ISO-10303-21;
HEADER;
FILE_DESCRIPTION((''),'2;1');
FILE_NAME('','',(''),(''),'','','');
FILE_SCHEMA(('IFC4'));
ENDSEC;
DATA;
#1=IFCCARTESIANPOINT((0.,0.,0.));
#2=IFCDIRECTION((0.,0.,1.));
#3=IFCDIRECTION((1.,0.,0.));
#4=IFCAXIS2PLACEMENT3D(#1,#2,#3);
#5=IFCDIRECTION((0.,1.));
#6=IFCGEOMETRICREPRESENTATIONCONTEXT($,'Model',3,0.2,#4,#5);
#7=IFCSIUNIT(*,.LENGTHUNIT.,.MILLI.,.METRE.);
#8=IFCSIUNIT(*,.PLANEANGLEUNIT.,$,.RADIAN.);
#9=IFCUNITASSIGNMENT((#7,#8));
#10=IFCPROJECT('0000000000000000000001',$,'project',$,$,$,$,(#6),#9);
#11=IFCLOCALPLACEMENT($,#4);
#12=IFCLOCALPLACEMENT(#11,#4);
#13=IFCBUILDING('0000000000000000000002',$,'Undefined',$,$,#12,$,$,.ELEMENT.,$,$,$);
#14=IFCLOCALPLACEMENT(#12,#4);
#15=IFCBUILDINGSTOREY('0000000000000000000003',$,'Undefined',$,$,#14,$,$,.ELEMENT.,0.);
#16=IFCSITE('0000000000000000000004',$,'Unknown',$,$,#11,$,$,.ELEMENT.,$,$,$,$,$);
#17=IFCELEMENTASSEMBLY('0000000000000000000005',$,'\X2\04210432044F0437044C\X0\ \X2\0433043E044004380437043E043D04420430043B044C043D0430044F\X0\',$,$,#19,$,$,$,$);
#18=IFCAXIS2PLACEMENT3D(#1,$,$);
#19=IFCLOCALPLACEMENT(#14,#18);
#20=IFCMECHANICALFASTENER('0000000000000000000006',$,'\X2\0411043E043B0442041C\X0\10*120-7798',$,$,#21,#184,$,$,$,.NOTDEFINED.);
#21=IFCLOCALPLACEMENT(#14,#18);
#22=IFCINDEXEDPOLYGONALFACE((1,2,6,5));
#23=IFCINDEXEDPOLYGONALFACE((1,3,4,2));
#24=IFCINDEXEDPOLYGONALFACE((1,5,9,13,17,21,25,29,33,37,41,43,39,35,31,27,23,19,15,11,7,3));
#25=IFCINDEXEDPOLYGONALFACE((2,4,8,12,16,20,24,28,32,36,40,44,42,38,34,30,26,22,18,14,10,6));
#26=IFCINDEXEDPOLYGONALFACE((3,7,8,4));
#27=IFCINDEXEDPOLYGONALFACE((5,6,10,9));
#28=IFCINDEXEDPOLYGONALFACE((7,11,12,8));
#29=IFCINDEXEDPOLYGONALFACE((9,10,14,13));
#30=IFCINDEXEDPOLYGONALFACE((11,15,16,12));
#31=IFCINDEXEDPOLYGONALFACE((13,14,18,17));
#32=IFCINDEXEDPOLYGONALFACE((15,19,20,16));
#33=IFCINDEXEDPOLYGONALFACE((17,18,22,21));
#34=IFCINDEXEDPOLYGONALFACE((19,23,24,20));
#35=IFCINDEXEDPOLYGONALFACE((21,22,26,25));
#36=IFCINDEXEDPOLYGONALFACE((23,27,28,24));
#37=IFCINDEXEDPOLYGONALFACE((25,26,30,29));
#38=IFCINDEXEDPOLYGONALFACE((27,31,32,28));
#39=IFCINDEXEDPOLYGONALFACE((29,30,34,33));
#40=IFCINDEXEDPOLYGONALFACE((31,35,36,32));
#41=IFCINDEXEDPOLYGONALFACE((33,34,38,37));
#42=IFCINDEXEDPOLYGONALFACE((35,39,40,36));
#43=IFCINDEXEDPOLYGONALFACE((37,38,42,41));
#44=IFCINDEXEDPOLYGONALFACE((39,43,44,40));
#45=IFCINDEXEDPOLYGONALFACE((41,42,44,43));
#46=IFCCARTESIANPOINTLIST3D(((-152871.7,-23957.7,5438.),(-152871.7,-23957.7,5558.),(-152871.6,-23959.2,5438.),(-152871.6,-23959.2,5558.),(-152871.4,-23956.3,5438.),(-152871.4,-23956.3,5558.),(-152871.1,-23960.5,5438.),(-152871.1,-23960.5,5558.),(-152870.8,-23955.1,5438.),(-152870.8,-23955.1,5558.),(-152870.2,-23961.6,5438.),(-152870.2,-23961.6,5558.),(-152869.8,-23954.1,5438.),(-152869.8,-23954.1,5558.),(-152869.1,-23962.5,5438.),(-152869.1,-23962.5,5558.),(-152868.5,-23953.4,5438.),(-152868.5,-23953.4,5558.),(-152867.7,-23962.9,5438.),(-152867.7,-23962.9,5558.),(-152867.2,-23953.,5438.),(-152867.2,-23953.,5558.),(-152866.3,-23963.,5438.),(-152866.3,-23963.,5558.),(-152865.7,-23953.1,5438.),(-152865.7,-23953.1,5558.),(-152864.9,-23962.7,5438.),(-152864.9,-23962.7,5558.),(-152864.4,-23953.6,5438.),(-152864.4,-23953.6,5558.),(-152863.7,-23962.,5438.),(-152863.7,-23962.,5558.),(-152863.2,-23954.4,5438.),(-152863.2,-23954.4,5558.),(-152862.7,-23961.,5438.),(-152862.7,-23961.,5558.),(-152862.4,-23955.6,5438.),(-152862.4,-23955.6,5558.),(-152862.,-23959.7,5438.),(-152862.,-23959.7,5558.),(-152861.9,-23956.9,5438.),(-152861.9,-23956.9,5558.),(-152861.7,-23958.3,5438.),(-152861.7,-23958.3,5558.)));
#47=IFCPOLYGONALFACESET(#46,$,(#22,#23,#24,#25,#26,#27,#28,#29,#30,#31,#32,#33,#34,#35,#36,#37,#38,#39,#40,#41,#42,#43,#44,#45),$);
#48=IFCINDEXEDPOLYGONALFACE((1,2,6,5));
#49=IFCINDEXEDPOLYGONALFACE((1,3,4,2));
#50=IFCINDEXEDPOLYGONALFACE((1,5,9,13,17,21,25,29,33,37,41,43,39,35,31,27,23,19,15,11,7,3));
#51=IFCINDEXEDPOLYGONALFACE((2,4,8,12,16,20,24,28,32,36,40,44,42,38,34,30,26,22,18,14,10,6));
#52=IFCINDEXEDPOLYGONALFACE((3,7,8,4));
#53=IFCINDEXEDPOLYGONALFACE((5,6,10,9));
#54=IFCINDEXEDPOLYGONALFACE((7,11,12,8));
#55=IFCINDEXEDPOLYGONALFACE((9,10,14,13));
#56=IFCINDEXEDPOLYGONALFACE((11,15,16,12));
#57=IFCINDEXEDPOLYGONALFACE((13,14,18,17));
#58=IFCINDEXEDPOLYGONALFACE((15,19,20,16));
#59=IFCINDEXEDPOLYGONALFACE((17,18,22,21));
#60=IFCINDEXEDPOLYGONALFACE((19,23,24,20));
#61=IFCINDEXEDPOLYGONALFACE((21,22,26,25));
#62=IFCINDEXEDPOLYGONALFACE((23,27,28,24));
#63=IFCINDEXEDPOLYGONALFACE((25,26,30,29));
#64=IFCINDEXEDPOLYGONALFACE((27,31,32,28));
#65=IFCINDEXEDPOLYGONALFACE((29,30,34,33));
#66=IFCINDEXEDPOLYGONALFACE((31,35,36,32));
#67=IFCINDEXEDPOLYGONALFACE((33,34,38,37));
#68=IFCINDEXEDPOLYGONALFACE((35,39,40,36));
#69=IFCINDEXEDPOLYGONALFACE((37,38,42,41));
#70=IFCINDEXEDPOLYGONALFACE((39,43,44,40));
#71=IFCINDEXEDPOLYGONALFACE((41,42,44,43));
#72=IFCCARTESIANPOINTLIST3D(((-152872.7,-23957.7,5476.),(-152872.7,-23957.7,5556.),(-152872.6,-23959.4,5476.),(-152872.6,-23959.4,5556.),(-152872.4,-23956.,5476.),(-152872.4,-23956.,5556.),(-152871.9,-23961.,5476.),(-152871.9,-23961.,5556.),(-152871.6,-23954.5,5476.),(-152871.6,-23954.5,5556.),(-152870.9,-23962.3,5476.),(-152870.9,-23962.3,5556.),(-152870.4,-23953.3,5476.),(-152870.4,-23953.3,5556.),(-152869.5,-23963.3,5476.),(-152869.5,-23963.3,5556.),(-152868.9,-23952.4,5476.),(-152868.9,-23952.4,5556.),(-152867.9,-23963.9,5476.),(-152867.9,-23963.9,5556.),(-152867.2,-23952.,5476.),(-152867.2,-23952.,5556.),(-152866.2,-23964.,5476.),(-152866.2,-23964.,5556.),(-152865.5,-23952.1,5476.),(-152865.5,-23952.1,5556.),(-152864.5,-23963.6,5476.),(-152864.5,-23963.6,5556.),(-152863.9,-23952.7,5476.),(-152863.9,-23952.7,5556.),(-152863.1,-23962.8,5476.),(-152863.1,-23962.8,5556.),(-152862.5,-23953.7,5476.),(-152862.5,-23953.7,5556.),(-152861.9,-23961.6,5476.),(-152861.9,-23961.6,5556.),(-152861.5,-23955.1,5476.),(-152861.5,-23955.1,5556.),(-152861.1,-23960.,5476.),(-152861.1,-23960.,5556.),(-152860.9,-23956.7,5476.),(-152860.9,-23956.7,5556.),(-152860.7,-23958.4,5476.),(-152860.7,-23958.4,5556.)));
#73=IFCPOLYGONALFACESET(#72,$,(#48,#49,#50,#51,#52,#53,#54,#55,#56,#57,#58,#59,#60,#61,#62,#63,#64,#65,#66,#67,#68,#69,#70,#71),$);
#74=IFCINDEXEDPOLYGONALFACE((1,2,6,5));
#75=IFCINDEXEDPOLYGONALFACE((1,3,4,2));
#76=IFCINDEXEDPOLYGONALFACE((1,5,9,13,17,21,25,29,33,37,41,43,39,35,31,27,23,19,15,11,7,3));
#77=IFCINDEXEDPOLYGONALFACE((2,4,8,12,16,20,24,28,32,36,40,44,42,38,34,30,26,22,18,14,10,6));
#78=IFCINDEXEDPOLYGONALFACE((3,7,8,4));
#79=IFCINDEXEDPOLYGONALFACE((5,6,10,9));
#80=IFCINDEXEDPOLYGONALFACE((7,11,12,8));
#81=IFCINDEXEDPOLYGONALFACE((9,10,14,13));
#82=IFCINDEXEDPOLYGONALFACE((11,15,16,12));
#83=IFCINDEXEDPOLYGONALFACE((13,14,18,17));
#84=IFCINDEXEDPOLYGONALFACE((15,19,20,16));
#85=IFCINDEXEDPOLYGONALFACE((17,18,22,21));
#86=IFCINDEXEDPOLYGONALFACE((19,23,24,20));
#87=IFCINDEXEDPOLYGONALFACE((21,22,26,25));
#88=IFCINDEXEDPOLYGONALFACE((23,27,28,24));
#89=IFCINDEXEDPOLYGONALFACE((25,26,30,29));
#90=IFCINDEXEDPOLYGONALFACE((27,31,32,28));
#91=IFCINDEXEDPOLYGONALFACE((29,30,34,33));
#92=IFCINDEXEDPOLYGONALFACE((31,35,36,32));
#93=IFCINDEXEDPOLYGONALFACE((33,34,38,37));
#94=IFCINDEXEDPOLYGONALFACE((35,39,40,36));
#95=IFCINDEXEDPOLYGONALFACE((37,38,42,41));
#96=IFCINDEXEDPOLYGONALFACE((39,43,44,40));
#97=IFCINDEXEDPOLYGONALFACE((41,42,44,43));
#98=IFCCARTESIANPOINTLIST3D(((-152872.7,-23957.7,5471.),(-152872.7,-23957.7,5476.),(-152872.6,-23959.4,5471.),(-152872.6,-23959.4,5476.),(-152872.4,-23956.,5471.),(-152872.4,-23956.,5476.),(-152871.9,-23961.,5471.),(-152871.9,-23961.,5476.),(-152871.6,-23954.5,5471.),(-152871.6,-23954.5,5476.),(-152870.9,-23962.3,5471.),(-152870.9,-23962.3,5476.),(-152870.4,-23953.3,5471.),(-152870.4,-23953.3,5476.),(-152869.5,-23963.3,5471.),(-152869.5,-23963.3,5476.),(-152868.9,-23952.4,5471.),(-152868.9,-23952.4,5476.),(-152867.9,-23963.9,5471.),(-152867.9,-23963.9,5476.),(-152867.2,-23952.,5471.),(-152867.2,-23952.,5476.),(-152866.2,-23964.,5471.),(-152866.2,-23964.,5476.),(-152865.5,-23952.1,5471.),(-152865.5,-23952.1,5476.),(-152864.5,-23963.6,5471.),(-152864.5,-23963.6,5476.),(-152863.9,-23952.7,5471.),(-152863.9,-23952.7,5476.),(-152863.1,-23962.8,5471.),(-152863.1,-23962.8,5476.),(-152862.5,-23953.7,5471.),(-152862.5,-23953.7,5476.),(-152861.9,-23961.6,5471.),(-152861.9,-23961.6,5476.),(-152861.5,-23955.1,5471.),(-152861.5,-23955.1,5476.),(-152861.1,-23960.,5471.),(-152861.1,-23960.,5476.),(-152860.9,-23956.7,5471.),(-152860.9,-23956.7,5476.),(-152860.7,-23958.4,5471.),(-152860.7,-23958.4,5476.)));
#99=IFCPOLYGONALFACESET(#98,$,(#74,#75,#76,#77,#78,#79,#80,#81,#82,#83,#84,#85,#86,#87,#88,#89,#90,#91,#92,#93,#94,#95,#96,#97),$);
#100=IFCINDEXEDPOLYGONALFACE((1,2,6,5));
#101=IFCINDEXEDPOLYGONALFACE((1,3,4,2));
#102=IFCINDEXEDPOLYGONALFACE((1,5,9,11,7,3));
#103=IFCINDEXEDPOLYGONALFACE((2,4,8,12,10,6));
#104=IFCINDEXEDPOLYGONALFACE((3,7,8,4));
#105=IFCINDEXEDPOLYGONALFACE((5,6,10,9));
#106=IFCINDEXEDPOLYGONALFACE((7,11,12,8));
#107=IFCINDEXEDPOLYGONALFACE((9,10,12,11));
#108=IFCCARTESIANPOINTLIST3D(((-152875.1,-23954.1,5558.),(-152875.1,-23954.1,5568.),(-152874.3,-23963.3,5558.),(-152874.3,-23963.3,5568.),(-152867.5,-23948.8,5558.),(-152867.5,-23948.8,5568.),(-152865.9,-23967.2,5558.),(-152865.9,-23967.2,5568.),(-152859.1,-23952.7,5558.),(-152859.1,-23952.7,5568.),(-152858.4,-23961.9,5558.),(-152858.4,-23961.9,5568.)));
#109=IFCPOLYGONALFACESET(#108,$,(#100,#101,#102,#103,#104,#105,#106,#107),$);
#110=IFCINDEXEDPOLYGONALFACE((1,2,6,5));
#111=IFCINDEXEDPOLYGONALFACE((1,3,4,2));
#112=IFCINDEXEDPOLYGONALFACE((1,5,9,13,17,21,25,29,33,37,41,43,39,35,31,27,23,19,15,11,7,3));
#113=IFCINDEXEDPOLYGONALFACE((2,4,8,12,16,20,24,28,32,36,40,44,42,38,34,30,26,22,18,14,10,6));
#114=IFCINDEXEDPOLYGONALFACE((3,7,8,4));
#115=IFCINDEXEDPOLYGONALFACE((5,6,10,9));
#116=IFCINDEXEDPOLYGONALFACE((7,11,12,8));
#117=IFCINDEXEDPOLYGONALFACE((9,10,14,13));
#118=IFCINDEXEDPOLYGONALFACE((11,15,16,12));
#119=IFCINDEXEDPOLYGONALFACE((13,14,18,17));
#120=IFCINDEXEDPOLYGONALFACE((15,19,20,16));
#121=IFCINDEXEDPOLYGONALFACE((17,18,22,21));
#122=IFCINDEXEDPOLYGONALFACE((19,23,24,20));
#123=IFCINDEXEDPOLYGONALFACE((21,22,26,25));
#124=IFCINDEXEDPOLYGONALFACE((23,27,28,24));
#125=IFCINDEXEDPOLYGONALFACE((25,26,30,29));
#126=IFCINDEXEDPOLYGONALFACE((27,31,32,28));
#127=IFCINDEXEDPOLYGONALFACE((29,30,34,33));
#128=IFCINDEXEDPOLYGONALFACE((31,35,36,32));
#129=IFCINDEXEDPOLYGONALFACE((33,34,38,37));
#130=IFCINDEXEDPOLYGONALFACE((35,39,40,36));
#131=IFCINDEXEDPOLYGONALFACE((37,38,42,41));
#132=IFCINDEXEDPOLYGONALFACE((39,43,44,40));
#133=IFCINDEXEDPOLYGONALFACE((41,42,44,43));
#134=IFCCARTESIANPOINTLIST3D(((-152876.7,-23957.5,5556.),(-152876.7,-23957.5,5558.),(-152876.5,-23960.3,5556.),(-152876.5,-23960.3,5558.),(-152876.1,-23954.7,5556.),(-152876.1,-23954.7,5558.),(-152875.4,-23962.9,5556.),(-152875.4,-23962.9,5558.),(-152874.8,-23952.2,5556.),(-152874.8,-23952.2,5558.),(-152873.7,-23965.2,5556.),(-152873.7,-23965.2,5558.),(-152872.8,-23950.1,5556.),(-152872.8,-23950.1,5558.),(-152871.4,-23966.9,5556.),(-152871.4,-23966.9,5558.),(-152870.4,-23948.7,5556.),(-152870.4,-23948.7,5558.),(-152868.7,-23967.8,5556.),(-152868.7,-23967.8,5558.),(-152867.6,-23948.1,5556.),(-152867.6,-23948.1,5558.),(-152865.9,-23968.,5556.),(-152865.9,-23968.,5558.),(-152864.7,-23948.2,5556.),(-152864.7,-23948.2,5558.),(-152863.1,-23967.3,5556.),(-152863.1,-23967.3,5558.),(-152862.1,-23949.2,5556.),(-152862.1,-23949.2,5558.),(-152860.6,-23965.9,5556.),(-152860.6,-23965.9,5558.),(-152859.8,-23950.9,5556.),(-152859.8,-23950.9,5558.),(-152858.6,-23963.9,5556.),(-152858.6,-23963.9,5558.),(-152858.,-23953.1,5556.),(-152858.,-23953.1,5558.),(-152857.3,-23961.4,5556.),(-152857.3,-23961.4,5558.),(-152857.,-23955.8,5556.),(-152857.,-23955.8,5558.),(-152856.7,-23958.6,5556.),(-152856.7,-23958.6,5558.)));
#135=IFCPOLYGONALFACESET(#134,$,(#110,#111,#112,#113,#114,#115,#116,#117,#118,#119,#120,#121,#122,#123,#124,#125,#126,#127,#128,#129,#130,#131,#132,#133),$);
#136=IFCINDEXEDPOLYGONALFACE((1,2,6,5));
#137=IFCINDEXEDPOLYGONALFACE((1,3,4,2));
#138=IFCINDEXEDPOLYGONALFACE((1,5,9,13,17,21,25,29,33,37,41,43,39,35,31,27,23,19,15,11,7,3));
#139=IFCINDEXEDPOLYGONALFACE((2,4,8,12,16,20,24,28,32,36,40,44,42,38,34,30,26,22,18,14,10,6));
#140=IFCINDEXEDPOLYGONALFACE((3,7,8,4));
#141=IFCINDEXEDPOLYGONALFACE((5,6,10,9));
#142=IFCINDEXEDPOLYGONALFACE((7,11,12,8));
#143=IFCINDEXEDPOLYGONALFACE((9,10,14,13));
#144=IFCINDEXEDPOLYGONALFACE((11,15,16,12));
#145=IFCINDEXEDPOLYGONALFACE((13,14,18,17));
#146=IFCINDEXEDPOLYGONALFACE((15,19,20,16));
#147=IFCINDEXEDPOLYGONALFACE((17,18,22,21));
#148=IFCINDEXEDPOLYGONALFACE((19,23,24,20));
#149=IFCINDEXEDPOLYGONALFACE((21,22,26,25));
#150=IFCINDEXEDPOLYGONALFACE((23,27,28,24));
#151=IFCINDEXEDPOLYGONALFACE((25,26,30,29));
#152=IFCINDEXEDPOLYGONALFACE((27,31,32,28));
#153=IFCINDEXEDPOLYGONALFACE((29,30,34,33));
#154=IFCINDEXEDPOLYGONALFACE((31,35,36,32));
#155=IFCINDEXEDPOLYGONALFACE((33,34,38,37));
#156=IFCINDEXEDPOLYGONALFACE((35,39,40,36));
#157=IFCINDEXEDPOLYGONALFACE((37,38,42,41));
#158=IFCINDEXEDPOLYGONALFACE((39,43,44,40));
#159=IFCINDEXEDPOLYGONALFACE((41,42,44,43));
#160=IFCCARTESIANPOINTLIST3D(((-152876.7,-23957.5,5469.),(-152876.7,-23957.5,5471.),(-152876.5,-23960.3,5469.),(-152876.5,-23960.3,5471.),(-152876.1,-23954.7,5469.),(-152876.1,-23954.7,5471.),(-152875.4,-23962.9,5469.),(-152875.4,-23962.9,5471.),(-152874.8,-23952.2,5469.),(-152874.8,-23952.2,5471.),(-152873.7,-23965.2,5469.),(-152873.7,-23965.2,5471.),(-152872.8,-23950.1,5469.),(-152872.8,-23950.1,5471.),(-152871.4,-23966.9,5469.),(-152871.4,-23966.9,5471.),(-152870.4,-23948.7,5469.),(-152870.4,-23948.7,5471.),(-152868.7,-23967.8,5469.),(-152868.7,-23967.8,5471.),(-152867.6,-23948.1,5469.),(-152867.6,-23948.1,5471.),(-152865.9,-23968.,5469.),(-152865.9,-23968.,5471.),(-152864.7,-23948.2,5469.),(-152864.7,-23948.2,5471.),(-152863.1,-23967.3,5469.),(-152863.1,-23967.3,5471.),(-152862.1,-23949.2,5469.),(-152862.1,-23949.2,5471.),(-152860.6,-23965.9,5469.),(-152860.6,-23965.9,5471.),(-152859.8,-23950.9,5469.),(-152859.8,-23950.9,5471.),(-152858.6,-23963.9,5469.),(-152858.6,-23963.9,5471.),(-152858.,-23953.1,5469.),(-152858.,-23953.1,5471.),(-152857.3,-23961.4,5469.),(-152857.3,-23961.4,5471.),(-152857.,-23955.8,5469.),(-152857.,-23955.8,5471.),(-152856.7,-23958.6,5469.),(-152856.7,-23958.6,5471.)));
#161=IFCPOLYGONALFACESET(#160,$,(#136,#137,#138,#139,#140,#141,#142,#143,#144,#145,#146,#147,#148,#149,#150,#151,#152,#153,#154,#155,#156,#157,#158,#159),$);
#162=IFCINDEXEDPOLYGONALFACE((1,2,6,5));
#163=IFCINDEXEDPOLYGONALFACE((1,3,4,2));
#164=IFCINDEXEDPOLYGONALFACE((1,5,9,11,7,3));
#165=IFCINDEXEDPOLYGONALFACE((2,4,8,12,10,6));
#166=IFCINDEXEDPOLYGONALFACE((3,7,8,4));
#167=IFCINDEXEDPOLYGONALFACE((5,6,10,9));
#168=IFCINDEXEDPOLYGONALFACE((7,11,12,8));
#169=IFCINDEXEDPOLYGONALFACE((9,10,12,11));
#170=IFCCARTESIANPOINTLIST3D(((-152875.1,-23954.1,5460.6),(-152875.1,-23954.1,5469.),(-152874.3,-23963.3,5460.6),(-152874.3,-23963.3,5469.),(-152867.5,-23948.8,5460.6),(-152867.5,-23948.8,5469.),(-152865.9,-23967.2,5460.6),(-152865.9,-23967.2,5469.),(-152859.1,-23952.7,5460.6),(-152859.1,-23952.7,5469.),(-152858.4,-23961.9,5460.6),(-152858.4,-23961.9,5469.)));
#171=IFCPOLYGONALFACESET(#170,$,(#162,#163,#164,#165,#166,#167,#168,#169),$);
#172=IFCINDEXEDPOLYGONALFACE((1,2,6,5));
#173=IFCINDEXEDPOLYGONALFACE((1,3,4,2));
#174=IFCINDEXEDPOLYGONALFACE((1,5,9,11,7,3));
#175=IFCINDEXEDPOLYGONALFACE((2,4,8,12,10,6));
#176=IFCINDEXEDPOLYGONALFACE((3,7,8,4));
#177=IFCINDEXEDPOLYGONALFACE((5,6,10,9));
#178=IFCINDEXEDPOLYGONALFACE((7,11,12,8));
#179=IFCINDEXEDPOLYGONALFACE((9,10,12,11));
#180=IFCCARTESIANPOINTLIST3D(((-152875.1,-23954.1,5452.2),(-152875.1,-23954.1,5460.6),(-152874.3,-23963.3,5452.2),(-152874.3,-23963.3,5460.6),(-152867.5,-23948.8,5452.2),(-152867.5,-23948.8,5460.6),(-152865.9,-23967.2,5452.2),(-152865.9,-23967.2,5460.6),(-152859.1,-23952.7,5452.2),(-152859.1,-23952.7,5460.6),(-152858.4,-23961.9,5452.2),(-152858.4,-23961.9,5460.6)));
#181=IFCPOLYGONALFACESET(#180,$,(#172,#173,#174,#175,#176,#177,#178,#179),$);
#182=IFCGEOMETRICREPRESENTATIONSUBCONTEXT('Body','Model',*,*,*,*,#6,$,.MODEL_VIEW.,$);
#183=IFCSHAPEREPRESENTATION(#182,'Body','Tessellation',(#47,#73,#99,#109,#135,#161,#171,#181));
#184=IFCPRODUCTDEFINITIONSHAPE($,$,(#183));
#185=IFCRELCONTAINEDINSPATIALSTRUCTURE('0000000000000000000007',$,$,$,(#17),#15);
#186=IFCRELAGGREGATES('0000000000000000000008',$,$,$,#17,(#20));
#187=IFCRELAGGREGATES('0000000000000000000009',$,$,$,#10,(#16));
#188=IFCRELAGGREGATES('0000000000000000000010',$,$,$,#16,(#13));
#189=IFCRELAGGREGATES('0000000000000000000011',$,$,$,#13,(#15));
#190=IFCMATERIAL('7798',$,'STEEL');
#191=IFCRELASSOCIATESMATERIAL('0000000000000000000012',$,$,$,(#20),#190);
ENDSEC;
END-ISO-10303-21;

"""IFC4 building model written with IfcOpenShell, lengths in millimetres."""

from ifc_helpers import new_model, si_unit, direction, frame, origin_with_axes, place, context, subcontext, project, spatial, line, arc, indexed_curve, outline, extrude, source, transform, mapped, material, element, aggregate, save


model = new_model("IFC4")

# Units and contexts
model_context = context("Model", 3, precision=0.2, world=origin_with_axes(), true_north=direction((0.0, 1.0)))
body_context = subcontext(model_context, "Body", "Model", "MODEL_VIEW")
ifc_project = project(units=[si_unit("LENGTHUNIT", "METRE", prefix="MILLI"), si_unit("PLANEANGLEUNIT", "RADIAN")], contexts=[model_context])

# Site, building, storey
site_placement = place(None, origin_with_axes())
site = spatial("IfcSite", under=ifc_project, at=site_placement, Name="Unknown", CompositionType="ELEMENT")
building_placement = place(site_placement, origin_with_axes())
building = spatial("IfcBuilding", under=site, at=building_placement, Name="Undefined", CompositionType="ELEMENT")
storey_placement = place(building_placement, origin_with_axes())
storey = spatial("IfcBuildingStorey", under=building, at=storey_placement, Name="Undefined", CompositionType="ELEMENT", Elevation=0.0)

# Element assembly
assembly_1_placement = place(storey_placement, frame((-153529.8, -23964.9, 5516.0), z_axis=(0.01183, -0.99993, 0.0), x_axis=(0.99993, 0.01183, 0.0)))
assembly_1 = element("IfcElementAssembly", 1, at=assembly_1_placement, inside=storey, Name="Связь горизонтальная")

# Shared definitions
ifc_material_1 = material(Name="7798", Category="STEEL")

# Mechanical fastener
shared_shape_1 = source(origin_with_axes(), body_context, "Body", "SweptSolid", [
    extrude(outline(indexed_curve([(5.0, 0.0), (0.0, 5.0), (-5.0, 0.0), (0.0, -5.0)], segments=[arc(1, 2, 3), arc(3, 4, 1)])), frame((0.0, 0.0, 87.0), z_axis=(0.0, 0.0, -1.0), x_axis=(0.0, 1.0, 0.0)), (0.0, 0.0, 1.0), 120.0),
    extrude(outline(indexed_curve([(6.0, 0.0), (0.0, 6.0), (-6.0, 0.0), (0.0, -6.0)], segments=[arc(1, 2, 3), arc(3, 4, 1)])), frame((0.0, 0.0, 85.0), z_axis=(0.0, 0.0, -1.0), x_axis=(0.0, 1.0, 0.0)), (0.0, 0.0, 1.0), 80.0),
    extrude(outline(indexed_curve([(6.0, 0.0), (0.0, 6.0), (-6.0, 0.0), (0.0, -6.0)], segments=[arc(1, 2, 3), arc(3, 4, 1)])), frame((0.0, 0.0, 5.0), z_axis=(0.0, 0.0, -1.0), x_axis=(0.0, 1.0, 0.0)), (0.0, 0.0, 1.0), 5.0),
    extrude(outline(indexed_curve([(9.2, 0.0), (4.6, 8.0), (-4.6, 8.0), (-9.2, 0.0), (-4.6, -8.0), (4.6, -8.0)], segments=[line(1, 2, 3, 4, 5, 6, 1)])), frame((0.0, 0.0, 97.0), z_axis=(0.0, 0.0, -1.0), x_axis=(0.0, 1.0, 0.0)), (0.0, 0.0, 1.0), 10.0),
    extrude(outline(indexed_curve([(10.0, 0.0), (0.0, 10.0), (-10.0, 0.0), (0.0, -10.0)], segments=[arc(1, 2, 3), arc(3, 4, 1)])), frame((0.0, 0.0, 87.0), z_axis=(0.0, 0.0, -1.0), x_axis=(0.0, 1.0, 0.0)), (0.0, 0.0, 1.0), 2.0),
    extrude(outline(indexed_curve([(10.0, 0.0), (0.0, 10.0), (-10.0, 0.0), (0.0, -10.0)], segments=[arc(1, 2, 3), arc(3, 4, 1)])), frame((0.0, 0.0, 0.0), z_axis=(0.0, 0.0, -1.0), x_axis=(0.0, 1.0, 0.0)), (0.0, 0.0, 1.0), 2.0),
    extrude(outline(indexed_curve([(9.2, 0.0), (4.6, 8.0), (-4.6, 8.0), (-9.2, 0.0), (-4.6, -8.0), (4.6, -8.0)], segments=[line(1, 2, 3, 4, 5, 6, 1)])), frame((0.0, 0.0, -2.0), z_axis=(0.0, 0.0, -1.0), x_axis=(0.0, 1.0, 0.0)), (0.0, 0.0, 1.0), 8.4),
    extrude(outline(indexed_curve([(9.2, 0.0), (4.6, 8.0), (-4.6, 8.0), (-9.2, 0.0), (-4.6, -8.0), (4.6, -8.0)], segments=[line(1, 2, 3, 4, 5, 6, 1)])), frame((0.0, 0.0, -10.4), z_axis=(0.0, 0.0, -1.0), x_axis=(0.0, 1.0, 0.0)), (0.0, 0.0, 1.0), 8.4),
])
mechanical_fastener_1_placement = place(assembly_1_placement, frame((663.1, -45.0, 1.0), z_axis=(0.0, 1.0, 0.0), x_axis=(0.997234, 0.0, -0.074322)))
mechanical_fastener_1 = element("IfcMechanicalFastener", 2, at=mechanical_fastener_1_placement, material=ifc_material_1, Name="БолтМ10*120-7798", PredefinedType="NOTDEFINED", context=body_context, shape_type="MappedRepresentation", body=[
    mapped(shared_shape_1, transform((0.0, 0.0, 0.0))),
])

aggregate(assembly_1, [mechanical_fastener_1])

save(model, "model.ifc")
